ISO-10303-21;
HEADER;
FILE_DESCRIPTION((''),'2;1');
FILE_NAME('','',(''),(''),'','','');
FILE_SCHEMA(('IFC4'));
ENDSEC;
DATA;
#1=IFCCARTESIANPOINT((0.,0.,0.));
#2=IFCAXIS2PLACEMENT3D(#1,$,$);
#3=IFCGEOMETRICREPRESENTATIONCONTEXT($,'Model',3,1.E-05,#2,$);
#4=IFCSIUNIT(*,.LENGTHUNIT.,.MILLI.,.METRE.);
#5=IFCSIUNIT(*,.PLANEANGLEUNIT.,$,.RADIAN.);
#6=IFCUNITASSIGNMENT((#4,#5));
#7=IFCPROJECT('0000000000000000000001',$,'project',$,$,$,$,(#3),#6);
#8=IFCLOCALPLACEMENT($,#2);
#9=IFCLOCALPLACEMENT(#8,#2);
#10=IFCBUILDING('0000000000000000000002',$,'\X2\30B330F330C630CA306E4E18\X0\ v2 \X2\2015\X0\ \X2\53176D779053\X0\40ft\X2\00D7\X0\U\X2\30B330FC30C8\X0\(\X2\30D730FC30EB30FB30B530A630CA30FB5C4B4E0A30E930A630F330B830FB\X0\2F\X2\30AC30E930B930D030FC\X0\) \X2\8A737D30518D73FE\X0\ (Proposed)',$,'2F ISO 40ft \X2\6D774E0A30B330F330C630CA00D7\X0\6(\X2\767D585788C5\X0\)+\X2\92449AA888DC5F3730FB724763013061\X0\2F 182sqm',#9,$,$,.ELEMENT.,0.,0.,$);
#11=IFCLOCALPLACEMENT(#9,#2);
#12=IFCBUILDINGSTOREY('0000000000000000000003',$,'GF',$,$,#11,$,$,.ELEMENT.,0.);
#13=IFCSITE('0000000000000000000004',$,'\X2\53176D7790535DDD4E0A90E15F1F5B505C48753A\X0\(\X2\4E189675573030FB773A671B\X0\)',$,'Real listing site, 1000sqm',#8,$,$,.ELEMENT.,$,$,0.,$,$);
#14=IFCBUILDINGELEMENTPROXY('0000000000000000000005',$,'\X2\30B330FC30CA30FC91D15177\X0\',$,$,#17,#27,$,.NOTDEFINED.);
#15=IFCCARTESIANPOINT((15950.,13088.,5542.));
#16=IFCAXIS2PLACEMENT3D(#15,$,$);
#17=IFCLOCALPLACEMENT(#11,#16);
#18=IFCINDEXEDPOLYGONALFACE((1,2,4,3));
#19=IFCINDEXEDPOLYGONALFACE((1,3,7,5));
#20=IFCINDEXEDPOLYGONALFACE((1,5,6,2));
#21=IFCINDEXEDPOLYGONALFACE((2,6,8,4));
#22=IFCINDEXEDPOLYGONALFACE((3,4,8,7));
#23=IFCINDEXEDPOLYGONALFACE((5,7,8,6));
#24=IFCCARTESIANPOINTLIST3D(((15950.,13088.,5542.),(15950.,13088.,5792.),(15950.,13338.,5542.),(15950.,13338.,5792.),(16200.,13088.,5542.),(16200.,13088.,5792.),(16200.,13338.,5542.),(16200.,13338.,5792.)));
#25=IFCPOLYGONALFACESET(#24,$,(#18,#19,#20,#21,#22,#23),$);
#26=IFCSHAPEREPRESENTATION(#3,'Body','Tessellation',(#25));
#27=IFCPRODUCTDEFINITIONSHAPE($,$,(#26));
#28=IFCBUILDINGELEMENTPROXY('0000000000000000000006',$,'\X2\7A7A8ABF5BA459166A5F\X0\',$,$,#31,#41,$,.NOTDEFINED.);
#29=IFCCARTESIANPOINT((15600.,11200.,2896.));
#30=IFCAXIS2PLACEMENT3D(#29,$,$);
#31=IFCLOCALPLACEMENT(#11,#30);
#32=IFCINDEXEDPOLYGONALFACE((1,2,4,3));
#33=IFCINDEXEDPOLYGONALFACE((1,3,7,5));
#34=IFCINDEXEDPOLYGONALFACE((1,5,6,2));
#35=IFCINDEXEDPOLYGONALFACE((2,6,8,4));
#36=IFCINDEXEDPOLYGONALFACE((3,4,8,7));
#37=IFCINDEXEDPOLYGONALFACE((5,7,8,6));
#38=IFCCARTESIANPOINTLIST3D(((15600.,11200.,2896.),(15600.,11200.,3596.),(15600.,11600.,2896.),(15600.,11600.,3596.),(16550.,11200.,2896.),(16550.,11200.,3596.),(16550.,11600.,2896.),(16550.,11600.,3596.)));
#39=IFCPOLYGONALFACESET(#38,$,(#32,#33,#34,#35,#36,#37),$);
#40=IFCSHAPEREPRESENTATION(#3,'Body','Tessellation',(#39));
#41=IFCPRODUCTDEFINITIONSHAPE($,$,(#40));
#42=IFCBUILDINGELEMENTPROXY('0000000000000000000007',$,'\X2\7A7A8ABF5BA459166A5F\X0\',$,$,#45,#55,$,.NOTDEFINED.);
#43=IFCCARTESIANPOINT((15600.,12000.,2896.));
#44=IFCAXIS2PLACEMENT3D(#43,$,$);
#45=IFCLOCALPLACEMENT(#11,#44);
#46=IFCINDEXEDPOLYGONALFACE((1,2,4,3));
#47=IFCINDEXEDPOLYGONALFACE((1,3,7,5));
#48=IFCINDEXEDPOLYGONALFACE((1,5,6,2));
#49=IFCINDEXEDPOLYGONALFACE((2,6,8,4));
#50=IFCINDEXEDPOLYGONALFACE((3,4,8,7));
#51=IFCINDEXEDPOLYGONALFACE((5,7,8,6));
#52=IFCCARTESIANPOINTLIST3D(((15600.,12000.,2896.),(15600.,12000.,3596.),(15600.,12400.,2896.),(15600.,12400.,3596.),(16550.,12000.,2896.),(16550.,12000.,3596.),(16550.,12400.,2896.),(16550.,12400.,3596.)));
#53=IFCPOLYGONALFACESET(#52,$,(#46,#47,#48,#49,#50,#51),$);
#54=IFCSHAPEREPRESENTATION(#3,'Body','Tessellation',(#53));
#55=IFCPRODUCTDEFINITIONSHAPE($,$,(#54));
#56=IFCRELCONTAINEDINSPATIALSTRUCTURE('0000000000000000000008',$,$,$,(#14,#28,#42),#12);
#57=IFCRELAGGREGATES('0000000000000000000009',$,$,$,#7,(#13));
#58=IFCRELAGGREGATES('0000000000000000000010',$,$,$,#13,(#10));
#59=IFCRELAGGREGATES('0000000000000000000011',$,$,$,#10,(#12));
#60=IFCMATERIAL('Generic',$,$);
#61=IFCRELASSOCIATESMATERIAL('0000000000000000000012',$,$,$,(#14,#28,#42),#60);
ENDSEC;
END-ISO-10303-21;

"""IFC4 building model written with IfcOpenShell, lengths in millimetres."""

from ifc_helpers import new_model, si_unit, frame, frame_2d, origin, place, context, project, spatial, rectangle, extrude, material, element, save


model = new_model("IFC4")

# Units and contexts
model_context = context("Model", 3, precision=1e-05, world=origin())
ifc_project = project(units=[si_unit("LENGTHUNIT", "METRE", prefix="MILLI"), si_unit("PLANEANGLEUNIT", "RADIAN")], contexts=[model_context])

# Site, building, storey
site_placement = place(None, origin())
site = spatial("IfcSite", under=ifc_project, at=site_placement, Name="北海道川上郡弟子屈町(丘陵地・眺望)", ObjectType="Real listing site, 1000sqm", CompositionType="ELEMENT", RefElevation=0.0)
building_placement = place(site_placement, origin())
building = spatial("IfcBuilding", under=site, at=building_placement, Name="コンテナの丘 v2 ― 北海道40ft×Uコート(プール・サウナ・屋上ラウンジ・2Fガラスバー) 詳細再現 (Proposed)", ObjectType="2F ISO 40ft 海上コンテナ×6(白塗装)+鉄骨補強・片持ち2F 182sqm", CompositionType="ELEMENT", ElevationOfRefHeight=0.0, ElevationOfTerrain=0.0)
storey_placement = place(building_placement, origin())
storey = spatial("IfcBuildingStorey", under=building, at=storey_placement, Name="GF", CompositionType="ELEMENT", Elevation=0.0)

# Shared definitions
ifc_material = material(Name="Generic")

# Building element proxies
proxy_1_placement = place(storey_placement, frame((15950.0, 13088.0, 5542.0)))
element("IfcBuildingElementProxy", 1, at=proxy_1_placement, inside=storey, material=ifc_material, Name="コーナー金具", PredefinedType="NOTDEFINED", context=model_context, shape_type="SweptSolid", body=[
    extrude(rectangle(XDim=250.0, YDim=250.0, at=frame_2d((125.0, 125.0))), frame((15950.0, 13088.0, 5542.0)), (0.0, 0.0, 1.0), 250.0),
])
proxy_2_placement = place(storey_placement, frame((15600.0, 11200.0, 2896.0)))
element("IfcBuildingElementProxy", 2, at=proxy_2_placement, inside=storey, material=ifc_material, Name="空調室外機", PredefinedType="NOTDEFINED", context=model_context, shape_type="SweptSolid", body=[
    extrude(rectangle(XDim=950.0, YDim=400.0, at=frame_2d((475.0, 200.0))), frame((15600.0, 11200.0, 2896.0)), (0.0, 0.0, 1.0), 700.0),
])
proxy_3_placement = place(storey_placement, frame((15600.0, 12000.0, 2896.0)))
element("IfcBuildingElementProxy", 3, at=proxy_3_placement, inside=storey, material=ifc_material, Name="空調室外機", PredefinedType="NOTDEFINED", context=model_context, shape_type="SweptSolid", body=[
    extrude(rectangle(XDim=950.0, YDim=400.0, at=frame_2d((475.0, 200.0))), frame((15600.0, 12000.0, 2896.0)), (0.0, 0.0, 1.0), 700.0),
])

save(model, "model.ifc")
